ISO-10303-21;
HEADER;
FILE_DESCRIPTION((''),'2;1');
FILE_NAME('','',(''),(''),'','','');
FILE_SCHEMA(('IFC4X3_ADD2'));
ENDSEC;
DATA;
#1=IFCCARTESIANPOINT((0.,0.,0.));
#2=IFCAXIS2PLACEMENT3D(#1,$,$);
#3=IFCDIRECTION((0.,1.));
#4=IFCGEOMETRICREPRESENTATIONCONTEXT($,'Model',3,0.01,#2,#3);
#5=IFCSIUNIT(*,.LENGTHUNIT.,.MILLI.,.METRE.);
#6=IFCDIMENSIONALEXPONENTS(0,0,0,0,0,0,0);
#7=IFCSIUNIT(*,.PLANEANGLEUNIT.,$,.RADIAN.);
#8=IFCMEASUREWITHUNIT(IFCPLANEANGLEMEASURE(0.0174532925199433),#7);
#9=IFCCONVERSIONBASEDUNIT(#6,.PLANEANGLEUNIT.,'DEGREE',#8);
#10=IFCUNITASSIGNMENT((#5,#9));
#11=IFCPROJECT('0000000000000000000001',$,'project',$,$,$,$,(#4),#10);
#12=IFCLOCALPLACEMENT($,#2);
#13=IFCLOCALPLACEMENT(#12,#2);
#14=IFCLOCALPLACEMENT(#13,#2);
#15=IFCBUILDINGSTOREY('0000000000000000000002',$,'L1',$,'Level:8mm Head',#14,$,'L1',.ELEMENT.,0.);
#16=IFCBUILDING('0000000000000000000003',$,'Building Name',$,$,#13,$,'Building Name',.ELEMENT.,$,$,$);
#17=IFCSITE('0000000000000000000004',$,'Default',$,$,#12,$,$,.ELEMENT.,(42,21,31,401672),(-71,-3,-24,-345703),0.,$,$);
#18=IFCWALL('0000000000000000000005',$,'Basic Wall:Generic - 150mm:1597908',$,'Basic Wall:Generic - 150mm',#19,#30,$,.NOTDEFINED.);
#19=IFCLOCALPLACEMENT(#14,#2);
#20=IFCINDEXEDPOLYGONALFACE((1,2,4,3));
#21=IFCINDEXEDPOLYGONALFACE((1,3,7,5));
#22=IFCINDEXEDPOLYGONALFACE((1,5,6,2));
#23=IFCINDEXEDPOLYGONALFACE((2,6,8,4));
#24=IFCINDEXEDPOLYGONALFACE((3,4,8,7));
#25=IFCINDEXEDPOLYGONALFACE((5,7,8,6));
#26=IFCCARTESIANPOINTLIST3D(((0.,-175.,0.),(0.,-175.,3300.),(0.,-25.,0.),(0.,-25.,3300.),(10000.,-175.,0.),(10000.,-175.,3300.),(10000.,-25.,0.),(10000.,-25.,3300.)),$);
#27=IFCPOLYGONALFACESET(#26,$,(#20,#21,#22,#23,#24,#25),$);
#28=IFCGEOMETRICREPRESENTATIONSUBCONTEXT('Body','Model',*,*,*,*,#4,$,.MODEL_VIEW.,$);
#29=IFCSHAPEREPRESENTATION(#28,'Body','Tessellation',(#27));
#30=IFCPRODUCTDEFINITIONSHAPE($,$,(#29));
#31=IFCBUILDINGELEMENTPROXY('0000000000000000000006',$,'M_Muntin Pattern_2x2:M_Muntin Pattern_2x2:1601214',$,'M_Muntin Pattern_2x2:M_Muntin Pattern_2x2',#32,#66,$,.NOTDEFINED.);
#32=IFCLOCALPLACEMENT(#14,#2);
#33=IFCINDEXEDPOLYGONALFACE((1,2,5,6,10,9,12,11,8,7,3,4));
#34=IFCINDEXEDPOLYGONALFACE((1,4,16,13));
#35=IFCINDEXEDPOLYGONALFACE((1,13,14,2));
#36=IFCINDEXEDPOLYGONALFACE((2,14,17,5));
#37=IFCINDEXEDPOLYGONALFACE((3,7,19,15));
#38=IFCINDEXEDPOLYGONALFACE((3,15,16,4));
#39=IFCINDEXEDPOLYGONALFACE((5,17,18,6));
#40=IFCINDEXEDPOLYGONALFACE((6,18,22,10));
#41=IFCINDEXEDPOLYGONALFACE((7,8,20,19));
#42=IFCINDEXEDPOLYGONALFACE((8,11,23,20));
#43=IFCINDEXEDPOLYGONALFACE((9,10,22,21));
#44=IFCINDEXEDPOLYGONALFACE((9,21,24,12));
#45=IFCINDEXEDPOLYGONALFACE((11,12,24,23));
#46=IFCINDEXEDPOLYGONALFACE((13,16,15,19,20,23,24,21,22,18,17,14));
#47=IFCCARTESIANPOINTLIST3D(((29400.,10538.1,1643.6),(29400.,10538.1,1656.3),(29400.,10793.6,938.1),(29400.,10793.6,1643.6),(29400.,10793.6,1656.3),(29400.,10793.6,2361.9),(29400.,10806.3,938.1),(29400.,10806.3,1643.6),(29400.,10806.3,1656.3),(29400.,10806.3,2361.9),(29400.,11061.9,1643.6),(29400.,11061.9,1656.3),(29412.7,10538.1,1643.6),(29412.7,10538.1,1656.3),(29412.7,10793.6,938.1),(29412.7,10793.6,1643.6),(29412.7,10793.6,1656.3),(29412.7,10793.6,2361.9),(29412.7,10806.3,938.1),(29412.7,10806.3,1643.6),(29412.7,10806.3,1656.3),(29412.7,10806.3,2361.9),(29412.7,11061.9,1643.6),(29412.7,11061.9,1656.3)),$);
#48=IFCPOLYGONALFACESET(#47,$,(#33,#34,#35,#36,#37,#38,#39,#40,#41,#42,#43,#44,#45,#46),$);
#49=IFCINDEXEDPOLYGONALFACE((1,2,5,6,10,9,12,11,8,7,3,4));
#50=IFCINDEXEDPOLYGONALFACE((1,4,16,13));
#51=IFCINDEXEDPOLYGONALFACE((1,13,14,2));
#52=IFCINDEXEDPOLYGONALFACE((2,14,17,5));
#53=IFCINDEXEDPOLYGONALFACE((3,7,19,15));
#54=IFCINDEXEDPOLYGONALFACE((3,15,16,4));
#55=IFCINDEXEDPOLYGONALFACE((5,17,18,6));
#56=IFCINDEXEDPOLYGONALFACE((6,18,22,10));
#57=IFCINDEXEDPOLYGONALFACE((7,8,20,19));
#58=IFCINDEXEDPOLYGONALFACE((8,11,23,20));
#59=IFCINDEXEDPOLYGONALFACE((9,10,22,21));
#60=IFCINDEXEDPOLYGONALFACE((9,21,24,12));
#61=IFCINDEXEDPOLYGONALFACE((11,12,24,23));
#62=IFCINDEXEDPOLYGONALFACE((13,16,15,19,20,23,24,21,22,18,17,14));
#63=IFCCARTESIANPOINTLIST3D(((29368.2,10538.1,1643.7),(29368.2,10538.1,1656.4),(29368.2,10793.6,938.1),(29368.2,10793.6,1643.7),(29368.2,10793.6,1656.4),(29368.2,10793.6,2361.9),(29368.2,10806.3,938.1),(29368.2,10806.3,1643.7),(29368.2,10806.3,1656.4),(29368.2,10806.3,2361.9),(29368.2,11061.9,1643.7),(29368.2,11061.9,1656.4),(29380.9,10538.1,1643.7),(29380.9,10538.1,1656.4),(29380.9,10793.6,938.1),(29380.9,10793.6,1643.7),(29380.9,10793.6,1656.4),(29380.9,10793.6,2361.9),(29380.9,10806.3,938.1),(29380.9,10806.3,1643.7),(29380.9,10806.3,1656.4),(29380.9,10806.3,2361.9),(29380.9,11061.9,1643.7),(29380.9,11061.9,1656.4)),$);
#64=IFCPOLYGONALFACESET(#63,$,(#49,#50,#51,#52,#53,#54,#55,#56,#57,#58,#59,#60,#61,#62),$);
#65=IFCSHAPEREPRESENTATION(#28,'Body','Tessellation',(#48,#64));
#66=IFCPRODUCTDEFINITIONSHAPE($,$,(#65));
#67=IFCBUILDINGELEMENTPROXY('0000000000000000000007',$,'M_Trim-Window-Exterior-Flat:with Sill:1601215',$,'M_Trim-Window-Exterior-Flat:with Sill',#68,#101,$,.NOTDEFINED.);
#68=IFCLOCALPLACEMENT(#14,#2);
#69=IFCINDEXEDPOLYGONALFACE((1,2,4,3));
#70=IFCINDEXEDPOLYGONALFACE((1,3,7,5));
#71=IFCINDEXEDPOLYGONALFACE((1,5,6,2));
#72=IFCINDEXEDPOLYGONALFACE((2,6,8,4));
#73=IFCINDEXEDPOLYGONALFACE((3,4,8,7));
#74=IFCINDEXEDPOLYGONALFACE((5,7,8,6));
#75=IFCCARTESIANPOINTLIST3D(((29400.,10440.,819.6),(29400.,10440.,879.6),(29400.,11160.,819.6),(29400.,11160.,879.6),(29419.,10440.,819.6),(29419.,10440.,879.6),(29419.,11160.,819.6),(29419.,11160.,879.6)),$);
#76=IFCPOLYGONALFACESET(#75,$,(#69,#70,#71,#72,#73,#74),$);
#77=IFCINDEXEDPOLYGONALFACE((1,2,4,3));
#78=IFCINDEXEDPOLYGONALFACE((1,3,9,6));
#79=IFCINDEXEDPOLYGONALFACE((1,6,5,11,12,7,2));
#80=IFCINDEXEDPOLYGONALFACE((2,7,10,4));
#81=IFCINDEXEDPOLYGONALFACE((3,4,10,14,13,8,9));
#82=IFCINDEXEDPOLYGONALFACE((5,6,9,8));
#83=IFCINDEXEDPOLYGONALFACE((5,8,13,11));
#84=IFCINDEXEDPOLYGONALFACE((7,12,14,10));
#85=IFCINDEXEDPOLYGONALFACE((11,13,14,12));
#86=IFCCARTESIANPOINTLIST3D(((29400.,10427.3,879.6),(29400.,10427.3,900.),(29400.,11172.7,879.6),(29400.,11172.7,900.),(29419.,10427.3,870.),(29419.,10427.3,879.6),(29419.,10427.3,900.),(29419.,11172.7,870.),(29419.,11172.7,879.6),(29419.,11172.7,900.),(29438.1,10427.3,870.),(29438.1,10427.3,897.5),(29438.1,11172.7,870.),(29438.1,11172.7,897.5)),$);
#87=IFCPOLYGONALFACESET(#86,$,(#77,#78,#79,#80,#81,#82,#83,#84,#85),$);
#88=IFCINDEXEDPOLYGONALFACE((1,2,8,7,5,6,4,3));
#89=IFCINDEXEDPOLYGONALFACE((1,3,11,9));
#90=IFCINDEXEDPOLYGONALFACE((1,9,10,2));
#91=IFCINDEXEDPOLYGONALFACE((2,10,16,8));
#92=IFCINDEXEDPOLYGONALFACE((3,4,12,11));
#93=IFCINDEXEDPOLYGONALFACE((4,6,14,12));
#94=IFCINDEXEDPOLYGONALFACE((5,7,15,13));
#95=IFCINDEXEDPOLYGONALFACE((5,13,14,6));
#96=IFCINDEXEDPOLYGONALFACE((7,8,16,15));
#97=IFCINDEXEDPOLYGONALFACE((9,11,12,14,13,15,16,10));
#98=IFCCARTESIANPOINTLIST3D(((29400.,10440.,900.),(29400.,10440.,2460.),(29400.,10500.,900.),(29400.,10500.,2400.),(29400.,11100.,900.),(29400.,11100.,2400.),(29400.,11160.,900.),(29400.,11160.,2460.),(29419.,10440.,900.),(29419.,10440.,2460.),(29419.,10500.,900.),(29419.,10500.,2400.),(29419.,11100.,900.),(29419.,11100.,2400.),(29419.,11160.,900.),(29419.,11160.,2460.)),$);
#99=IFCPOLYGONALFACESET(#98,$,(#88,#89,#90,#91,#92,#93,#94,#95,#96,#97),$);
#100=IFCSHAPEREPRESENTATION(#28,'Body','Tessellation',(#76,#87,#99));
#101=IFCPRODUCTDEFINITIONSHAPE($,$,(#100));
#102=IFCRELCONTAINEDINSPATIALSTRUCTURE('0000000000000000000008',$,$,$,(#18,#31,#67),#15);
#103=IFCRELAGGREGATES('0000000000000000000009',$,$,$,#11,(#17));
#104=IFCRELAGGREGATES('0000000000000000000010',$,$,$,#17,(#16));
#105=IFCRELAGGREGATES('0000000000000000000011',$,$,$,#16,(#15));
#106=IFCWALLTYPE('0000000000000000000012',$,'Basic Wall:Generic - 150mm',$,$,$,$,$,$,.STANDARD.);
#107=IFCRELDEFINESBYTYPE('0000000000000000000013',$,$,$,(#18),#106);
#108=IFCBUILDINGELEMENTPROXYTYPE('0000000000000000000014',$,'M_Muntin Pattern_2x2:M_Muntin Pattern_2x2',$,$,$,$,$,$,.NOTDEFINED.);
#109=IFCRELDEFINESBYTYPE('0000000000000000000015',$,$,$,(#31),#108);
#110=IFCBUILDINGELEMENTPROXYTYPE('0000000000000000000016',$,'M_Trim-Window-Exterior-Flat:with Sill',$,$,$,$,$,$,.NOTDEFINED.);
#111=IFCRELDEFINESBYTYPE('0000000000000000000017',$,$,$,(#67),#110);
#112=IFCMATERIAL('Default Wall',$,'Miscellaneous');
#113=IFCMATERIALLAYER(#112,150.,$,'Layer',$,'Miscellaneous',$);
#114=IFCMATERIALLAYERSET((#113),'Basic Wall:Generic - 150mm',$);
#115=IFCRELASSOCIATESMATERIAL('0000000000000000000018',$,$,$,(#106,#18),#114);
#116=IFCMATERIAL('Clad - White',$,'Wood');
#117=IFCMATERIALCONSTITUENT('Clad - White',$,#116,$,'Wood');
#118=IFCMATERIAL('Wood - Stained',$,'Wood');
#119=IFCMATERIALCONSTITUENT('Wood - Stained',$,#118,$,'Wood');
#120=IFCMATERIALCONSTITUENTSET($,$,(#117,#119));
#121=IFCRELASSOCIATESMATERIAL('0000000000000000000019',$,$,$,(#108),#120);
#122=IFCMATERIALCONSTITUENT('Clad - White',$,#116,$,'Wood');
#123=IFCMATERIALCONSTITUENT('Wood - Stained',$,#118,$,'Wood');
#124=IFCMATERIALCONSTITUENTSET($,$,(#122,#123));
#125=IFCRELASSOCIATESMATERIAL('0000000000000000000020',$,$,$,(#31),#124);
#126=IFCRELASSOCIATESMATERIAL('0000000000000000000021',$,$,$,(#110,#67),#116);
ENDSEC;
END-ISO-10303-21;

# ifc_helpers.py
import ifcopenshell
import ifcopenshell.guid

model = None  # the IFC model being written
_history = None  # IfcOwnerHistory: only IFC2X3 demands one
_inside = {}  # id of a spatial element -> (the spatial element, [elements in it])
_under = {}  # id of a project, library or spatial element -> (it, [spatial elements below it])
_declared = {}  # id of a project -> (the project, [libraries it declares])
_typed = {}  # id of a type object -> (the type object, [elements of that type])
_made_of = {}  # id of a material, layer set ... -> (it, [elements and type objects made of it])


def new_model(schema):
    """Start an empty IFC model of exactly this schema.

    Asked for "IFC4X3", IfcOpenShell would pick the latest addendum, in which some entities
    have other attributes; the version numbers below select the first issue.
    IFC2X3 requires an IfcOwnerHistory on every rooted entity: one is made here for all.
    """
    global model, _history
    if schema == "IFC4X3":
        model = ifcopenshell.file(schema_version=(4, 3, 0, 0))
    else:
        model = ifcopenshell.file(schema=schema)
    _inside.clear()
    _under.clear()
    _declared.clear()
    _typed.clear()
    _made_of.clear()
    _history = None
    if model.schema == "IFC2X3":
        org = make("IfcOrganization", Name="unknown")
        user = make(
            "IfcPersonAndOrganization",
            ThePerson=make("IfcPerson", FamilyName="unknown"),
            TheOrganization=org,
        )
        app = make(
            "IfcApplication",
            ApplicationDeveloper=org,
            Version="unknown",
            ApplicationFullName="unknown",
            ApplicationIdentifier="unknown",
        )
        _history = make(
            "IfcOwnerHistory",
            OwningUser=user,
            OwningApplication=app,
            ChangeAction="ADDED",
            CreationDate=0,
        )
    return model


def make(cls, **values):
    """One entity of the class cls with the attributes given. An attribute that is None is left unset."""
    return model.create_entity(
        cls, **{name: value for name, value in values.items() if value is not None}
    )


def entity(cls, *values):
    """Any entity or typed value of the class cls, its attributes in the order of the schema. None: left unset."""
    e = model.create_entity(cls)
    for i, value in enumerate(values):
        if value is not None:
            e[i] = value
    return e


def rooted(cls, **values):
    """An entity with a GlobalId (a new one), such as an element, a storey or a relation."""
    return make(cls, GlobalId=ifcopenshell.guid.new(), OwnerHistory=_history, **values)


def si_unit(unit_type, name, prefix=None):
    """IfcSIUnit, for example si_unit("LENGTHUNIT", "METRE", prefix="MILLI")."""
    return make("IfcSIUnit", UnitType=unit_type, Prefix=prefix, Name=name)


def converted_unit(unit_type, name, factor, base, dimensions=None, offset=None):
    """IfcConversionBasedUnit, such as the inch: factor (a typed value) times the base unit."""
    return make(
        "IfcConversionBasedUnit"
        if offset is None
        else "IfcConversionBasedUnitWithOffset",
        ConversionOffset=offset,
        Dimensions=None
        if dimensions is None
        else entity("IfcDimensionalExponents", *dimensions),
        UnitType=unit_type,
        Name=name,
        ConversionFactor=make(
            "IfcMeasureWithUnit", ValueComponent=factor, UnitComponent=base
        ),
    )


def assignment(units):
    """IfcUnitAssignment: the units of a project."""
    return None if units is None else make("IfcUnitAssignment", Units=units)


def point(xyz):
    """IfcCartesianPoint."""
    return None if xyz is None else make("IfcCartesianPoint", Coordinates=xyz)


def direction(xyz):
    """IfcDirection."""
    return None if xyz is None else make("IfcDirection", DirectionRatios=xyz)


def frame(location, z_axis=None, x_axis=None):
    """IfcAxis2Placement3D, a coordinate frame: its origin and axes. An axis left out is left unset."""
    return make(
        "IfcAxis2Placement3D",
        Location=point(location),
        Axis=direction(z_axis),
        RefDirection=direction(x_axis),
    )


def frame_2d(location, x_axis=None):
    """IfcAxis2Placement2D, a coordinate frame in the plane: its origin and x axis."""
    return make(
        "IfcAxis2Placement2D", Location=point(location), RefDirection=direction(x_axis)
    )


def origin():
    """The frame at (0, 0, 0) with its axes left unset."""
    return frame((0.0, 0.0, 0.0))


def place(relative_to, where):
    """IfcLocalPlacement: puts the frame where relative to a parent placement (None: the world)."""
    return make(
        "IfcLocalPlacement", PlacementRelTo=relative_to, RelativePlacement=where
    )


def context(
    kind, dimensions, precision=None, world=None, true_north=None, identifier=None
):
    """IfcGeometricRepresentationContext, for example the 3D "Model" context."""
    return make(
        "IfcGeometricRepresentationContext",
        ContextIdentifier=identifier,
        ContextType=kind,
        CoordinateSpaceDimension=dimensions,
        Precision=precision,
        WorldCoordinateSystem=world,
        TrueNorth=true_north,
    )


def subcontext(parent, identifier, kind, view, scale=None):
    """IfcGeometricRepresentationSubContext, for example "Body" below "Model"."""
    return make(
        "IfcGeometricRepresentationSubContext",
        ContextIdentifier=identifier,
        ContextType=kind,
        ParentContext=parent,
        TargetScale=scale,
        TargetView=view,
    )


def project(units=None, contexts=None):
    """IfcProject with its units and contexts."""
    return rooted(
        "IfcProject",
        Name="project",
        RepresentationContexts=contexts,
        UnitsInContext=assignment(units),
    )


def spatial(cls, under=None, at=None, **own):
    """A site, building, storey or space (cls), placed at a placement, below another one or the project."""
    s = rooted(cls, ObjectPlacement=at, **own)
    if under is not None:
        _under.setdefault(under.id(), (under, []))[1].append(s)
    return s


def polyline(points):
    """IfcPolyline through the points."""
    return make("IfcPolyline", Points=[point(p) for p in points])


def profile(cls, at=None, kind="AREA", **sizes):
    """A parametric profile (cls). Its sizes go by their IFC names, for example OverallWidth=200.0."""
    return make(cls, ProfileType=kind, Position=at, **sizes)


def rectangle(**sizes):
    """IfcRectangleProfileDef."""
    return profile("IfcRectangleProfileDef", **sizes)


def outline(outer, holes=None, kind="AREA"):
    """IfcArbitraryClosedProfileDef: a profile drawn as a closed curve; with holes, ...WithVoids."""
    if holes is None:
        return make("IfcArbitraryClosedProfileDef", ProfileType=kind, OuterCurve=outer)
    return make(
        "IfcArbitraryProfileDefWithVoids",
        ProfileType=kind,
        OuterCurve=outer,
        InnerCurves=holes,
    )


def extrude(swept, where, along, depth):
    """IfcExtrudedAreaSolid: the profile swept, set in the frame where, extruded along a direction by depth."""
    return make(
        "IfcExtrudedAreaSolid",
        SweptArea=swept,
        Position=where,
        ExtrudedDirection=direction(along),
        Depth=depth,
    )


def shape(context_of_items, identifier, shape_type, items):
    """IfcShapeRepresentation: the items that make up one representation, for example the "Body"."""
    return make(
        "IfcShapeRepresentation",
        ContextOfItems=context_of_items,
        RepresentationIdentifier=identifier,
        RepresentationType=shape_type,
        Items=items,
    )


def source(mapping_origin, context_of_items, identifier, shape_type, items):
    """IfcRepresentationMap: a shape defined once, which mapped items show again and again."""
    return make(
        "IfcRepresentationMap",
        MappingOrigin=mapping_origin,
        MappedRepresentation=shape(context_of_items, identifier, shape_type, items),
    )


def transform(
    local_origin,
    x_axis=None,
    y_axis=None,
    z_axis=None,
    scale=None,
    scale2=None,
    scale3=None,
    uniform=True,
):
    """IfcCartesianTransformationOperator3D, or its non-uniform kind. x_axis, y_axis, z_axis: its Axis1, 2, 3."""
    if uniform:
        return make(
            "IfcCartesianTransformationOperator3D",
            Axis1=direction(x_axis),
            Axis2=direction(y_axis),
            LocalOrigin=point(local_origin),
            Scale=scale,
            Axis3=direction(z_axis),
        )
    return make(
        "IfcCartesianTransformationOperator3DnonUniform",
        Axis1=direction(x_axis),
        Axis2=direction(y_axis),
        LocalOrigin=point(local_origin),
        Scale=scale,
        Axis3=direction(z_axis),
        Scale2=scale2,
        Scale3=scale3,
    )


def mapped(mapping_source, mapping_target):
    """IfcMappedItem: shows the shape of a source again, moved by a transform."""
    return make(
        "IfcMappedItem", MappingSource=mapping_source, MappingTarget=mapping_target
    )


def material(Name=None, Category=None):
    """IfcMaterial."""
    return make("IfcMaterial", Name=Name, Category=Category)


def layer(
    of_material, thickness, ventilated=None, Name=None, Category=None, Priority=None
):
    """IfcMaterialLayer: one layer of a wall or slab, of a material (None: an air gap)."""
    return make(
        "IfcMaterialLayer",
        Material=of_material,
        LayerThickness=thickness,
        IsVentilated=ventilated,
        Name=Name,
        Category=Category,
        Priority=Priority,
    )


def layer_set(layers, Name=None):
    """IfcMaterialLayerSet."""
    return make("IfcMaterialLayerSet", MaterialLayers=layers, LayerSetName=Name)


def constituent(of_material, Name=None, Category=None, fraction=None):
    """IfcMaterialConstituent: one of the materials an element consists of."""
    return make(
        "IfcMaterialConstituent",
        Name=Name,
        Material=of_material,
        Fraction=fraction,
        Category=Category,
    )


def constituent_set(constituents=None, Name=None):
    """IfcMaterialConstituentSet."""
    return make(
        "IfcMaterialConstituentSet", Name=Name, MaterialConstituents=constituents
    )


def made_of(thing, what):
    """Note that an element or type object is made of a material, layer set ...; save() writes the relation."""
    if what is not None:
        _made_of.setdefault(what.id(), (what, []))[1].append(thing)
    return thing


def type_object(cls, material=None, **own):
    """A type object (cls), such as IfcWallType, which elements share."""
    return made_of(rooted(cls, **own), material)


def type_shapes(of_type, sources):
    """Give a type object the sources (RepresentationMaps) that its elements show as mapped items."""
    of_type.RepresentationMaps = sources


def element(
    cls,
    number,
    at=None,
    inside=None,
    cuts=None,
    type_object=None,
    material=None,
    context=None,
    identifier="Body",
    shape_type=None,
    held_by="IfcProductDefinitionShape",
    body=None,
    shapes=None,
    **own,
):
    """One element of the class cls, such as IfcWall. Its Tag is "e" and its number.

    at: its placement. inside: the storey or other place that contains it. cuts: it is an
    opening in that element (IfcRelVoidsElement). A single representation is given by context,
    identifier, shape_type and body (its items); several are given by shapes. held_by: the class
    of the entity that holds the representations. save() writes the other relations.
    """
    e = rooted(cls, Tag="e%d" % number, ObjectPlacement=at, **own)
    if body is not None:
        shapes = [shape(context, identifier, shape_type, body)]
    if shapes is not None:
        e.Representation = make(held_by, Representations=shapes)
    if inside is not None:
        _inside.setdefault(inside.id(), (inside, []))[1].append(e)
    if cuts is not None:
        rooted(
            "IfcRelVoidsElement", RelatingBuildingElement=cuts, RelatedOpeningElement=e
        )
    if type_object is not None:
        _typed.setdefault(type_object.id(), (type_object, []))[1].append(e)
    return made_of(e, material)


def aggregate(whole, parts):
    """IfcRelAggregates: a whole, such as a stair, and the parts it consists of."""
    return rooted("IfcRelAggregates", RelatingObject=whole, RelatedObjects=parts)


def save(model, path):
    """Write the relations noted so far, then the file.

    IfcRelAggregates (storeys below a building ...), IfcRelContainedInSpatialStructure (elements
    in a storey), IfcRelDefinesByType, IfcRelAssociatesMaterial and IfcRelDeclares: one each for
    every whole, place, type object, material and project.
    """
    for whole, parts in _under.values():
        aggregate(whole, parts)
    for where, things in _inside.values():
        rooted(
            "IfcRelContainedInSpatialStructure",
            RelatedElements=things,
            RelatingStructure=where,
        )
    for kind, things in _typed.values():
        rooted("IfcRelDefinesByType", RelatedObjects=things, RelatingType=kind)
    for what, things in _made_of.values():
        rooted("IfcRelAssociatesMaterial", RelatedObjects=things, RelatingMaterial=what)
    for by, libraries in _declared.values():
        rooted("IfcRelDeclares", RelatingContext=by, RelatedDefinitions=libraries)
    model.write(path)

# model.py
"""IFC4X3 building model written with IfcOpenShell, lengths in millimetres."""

from ifc_helpers import new_model, entity, si_unit, converted_unit, direction, frame, frame_2d, origin, place, context, subcontext, project, spatial, polyline, rectangle, outline, extrude, source, transform, mapped, material, layer, layer_set, constituent, constituent_set, type_object, type_shapes, element, save


model = new_model("IFC4X3")

# Units and contexts
model_context = context("Model", 3, precision=0.01, world=origin(), true_north=direction((0.0, 1.0)))
body_context = subcontext(model_context, "Body", "Model", "MODEL_VIEW")
ifc_project = project(units=[si_unit("LENGTHUNIT", "METRE", prefix="MILLI"), converted_unit("PLANEANGLEUNIT", "DEGREE", entity("IfcPlaneAngleMeasure", 0.0174532925199433), si_unit("PLANEANGLEUNIT", "RADIAN"), dimensions=[0, 0, 0, 0, 0, 0, 0])], contexts=[model_context])

# Site, building, storey
site_placement = place(None, origin())
site = spatial("IfcSite", under=ifc_project, at=site_placement, Name="Default", CompositionType="ELEMENT", RefLatitude=(42, 21, 31, 401672), RefLongitude=(-71, -3, -24, -345703), RefElevation=0.0)
building_placement = place(site_placement, origin())
building = spatial("IfcBuilding", under=site, at=building_placement, Name="Building Name", LongName="Building Name", CompositionType="ELEMENT")
storey_placement = place(building_placement, origin())
storey = spatial("IfcBuildingStorey", under=building, at=storey_placement, Name="L1", ObjectType="Level:8mm Head", LongName="L1", CompositionType="ELEMENT", Elevation=0.0)

# Shared definitions
ifc_material_1 = material(Name="Default Wall", Category="Miscellaneous")

# Wall
ifc_layer_1 = layer(ifc_material_1, 150.0, Name="Layer", Category="Miscellaneous")
ifc_layer_set_1 = layer_set([ifc_layer_1], Name="Basic Wall:Generic - 150mm")
wall_type_1 = type_object("IfcWallType", Name="Basic Wall:Generic - 150mm", PredefinedType="STANDARD", material=ifc_layer_set_1)
wall_1_placement = place(storey_placement, frame((0.0, -100.0, 0.0)))
element("IfcWall", 1, at=wall_1_placement, inside=storey, type_object=wall_type_1, material=ifc_layer_set_1, Name="Basic Wall:Generic - 150mm:1597908", ObjectType="Basic Wall:Generic - 150mm", PredefinedType="NOTDEFINED", context=body_context, shape_type="SweptSolid", body=[
    extrude(rectangle(XDim=10000.0, YDim=150.0, at=frame_2d((5000.0, 0.0), x_axis=(-1.0, 0.0))), origin(), (0.0, 0.0, 1.0), 3300.0),
])

# Building element proxies
ifc_material_2 = material(Name="Clad - White", Category="Wood")
ifc_constituent_1 = constituent(ifc_material_2, Name="Clad - White", Category="Wood")
ifc_material_3 = material(Name="Wood - Stained", Category="Wood")
ifc_constituent_2 = constituent(ifc_material_3, Name="Wood - Stained", Category="Wood")
ifc_constituent_set_1 = constituent_set(constituents=[ifc_constituent_1, ifc_constituent_2])
ifc_constituent_3 = constituent(ifc_material_2, Name="Clad - White", Category="Wood")
ifc_constituent_4 = constituent(ifc_material_3, Name="Wood - Stained", Category="Wood")
ifc_constituent_set_2 = constituent_set(constituents=[ifc_constituent_3, ifc_constituent_4])
building_element_proxy_type_1 = type_object("IfcBuildingElementProxyType", Name="M_Muntin Pattern_2x2:M_Muntin Pattern_2x2", PredefinedType="NOTDEFINED", material=ifc_constituent_set_2)
shared_shape_1 = source(origin(), body_context, "Body", "SweptSolid", [
    extrude(outline(polyline([(6.4, -6.4), (711.9, -6.4), (711.9, 6.3), (6.4, 6.3), (6.4, 261.9), (-6.3, 261.9), (-6.3, 6.3), (-711.9, 6.3), (-711.9, -6.4), (-6.3, -6.4), (-6.3, -261.9), (6.4, -261.9), (6.4, -6.4)])), frame((0.0, -22.2, 711.9), z_axis=(0.0, 1.0, 0.0), x_axis=(0.0, 0.0, 1.0)), (0.0, 0.0, 1.0), 12.7),
    extrude(outline(polyline([(6.4, -6.4), (711.9, -6.4), (711.9, 6.3), (6.4, 6.3), (6.4, 261.9), (-6.3, 261.9), (-6.3, 6.3), (-711.9, 6.3), (-711.9, -6.4), (-6.3, -6.4), (-6.3, -261.9), (6.4, -261.9), (6.4, -6.4)])), frame((0.0, 9.5, 711.9), z_axis=(0.0, 1.0, 0.0), x_axis=(0.0, 0.0, 1.0)), (0.0, 0.0, 1.0), 12.7),
])
type_shapes(building_element_proxy_type_1, [shared_shape_1])
proxy_1_placement = place(storey_placement, frame((29390.5, 10800.0, 938.1), z_axis=(0.0, 0.0, 1.0), x_axis=(0.0, 1.0, 0.0)))
element("IfcBuildingElementProxy", 2, at=proxy_1_placement, inside=storey, type_object=building_element_proxy_type_1, material=ifc_constituent_set_1, Name="M_Muntin Pattern_2x2:M_Muntin Pattern_2x2:1601214", ObjectType="M_Muntin Pattern_2x2:M_Muntin Pattern_2x2", PredefinedType="NOTDEFINED", context=body_context, shape_type="MappedRepresentation", body=[
    mapped(shared_shape_1, transform((0.0, 0.0, 0.0), scale=1.0)),
])
building_element_proxy_type_2 = type_object("IfcBuildingElementProxyType", Name="M_Trim-Window-Exterior-Flat:with Sill", PredefinedType="NOTDEFINED", material=ifc_material_2)
shared_shape_2 = source(origin(), body_context, "Body", "SweptSolid", [
    extrude(rectangle(XDim=720.0, YDim=60.0, at=frame_2d((0.0, 0.0), x_axis=(1.0, 0.0))), frame((0.0, -1550.4, 0.0), z_axis=(0.0, 0.0, 1.0), x_axis=(-1.0, 0.0, 0.0)), (0.0, 0.0, 1.0), 19.1),
    extrude(outline(polyline([(-19.0, -15.2), (0.0, -15.2), (0.0, -5.7), (19.0, -5.7), (19.0, 14.8), (0.0, 14.8), (-19.0, 12.3), (-19.0, -15.2)])), frame((-372.7, -1514.8, 19.0), z_axis=(1.0, 0.0, 0.0), x_axis=(0.0, 0.0, -1.0)), (0.0, 0.0, 1.0), 745.4),
    extrude(outline(polyline([(-795.0, -360.0), (765.0, -360.0), (765.0, -300.0), (-735.0, -300.0), (-735.0, 300.0), (765.0, 300.0), (765.0, 360.0), (-795.0, 360.0), (-795.0, -360.0)])), frame((0.0, -735.0, 0.0), z_axis=(0.0, 0.0, 1.0), x_axis=(0.0, -1.0, 0.0)), (0.0, 0.0, 1.0), 19.1),
])
type_shapes(building_element_proxy_type_2, [shared_shape_2])
proxy_2_placement = place(storey_placement, frame((29400.0, 10800.0, 2400.0), z_axis=(1.0, 0.0, 0.0), x_axis=(0.0, 1.0, 0.0)))
element("IfcBuildingElementProxy", 3, at=proxy_2_placement, inside=storey, type_object=building_element_proxy_type_2, material=ifc_material_2, Name="M_Trim-Window-Exterior-Flat:with Sill:1601215", ObjectType="M_Trim-Window-Exterior-Flat:with Sill", PredefinedType="NOTDEFINED", context=body_context, shape_type="MappedRepresentation", body=[
    mapped(shared_shape_2, transform((0.0, 0.0, 0.0), scale=1.0)),
])

save(model, "model.ifc")
